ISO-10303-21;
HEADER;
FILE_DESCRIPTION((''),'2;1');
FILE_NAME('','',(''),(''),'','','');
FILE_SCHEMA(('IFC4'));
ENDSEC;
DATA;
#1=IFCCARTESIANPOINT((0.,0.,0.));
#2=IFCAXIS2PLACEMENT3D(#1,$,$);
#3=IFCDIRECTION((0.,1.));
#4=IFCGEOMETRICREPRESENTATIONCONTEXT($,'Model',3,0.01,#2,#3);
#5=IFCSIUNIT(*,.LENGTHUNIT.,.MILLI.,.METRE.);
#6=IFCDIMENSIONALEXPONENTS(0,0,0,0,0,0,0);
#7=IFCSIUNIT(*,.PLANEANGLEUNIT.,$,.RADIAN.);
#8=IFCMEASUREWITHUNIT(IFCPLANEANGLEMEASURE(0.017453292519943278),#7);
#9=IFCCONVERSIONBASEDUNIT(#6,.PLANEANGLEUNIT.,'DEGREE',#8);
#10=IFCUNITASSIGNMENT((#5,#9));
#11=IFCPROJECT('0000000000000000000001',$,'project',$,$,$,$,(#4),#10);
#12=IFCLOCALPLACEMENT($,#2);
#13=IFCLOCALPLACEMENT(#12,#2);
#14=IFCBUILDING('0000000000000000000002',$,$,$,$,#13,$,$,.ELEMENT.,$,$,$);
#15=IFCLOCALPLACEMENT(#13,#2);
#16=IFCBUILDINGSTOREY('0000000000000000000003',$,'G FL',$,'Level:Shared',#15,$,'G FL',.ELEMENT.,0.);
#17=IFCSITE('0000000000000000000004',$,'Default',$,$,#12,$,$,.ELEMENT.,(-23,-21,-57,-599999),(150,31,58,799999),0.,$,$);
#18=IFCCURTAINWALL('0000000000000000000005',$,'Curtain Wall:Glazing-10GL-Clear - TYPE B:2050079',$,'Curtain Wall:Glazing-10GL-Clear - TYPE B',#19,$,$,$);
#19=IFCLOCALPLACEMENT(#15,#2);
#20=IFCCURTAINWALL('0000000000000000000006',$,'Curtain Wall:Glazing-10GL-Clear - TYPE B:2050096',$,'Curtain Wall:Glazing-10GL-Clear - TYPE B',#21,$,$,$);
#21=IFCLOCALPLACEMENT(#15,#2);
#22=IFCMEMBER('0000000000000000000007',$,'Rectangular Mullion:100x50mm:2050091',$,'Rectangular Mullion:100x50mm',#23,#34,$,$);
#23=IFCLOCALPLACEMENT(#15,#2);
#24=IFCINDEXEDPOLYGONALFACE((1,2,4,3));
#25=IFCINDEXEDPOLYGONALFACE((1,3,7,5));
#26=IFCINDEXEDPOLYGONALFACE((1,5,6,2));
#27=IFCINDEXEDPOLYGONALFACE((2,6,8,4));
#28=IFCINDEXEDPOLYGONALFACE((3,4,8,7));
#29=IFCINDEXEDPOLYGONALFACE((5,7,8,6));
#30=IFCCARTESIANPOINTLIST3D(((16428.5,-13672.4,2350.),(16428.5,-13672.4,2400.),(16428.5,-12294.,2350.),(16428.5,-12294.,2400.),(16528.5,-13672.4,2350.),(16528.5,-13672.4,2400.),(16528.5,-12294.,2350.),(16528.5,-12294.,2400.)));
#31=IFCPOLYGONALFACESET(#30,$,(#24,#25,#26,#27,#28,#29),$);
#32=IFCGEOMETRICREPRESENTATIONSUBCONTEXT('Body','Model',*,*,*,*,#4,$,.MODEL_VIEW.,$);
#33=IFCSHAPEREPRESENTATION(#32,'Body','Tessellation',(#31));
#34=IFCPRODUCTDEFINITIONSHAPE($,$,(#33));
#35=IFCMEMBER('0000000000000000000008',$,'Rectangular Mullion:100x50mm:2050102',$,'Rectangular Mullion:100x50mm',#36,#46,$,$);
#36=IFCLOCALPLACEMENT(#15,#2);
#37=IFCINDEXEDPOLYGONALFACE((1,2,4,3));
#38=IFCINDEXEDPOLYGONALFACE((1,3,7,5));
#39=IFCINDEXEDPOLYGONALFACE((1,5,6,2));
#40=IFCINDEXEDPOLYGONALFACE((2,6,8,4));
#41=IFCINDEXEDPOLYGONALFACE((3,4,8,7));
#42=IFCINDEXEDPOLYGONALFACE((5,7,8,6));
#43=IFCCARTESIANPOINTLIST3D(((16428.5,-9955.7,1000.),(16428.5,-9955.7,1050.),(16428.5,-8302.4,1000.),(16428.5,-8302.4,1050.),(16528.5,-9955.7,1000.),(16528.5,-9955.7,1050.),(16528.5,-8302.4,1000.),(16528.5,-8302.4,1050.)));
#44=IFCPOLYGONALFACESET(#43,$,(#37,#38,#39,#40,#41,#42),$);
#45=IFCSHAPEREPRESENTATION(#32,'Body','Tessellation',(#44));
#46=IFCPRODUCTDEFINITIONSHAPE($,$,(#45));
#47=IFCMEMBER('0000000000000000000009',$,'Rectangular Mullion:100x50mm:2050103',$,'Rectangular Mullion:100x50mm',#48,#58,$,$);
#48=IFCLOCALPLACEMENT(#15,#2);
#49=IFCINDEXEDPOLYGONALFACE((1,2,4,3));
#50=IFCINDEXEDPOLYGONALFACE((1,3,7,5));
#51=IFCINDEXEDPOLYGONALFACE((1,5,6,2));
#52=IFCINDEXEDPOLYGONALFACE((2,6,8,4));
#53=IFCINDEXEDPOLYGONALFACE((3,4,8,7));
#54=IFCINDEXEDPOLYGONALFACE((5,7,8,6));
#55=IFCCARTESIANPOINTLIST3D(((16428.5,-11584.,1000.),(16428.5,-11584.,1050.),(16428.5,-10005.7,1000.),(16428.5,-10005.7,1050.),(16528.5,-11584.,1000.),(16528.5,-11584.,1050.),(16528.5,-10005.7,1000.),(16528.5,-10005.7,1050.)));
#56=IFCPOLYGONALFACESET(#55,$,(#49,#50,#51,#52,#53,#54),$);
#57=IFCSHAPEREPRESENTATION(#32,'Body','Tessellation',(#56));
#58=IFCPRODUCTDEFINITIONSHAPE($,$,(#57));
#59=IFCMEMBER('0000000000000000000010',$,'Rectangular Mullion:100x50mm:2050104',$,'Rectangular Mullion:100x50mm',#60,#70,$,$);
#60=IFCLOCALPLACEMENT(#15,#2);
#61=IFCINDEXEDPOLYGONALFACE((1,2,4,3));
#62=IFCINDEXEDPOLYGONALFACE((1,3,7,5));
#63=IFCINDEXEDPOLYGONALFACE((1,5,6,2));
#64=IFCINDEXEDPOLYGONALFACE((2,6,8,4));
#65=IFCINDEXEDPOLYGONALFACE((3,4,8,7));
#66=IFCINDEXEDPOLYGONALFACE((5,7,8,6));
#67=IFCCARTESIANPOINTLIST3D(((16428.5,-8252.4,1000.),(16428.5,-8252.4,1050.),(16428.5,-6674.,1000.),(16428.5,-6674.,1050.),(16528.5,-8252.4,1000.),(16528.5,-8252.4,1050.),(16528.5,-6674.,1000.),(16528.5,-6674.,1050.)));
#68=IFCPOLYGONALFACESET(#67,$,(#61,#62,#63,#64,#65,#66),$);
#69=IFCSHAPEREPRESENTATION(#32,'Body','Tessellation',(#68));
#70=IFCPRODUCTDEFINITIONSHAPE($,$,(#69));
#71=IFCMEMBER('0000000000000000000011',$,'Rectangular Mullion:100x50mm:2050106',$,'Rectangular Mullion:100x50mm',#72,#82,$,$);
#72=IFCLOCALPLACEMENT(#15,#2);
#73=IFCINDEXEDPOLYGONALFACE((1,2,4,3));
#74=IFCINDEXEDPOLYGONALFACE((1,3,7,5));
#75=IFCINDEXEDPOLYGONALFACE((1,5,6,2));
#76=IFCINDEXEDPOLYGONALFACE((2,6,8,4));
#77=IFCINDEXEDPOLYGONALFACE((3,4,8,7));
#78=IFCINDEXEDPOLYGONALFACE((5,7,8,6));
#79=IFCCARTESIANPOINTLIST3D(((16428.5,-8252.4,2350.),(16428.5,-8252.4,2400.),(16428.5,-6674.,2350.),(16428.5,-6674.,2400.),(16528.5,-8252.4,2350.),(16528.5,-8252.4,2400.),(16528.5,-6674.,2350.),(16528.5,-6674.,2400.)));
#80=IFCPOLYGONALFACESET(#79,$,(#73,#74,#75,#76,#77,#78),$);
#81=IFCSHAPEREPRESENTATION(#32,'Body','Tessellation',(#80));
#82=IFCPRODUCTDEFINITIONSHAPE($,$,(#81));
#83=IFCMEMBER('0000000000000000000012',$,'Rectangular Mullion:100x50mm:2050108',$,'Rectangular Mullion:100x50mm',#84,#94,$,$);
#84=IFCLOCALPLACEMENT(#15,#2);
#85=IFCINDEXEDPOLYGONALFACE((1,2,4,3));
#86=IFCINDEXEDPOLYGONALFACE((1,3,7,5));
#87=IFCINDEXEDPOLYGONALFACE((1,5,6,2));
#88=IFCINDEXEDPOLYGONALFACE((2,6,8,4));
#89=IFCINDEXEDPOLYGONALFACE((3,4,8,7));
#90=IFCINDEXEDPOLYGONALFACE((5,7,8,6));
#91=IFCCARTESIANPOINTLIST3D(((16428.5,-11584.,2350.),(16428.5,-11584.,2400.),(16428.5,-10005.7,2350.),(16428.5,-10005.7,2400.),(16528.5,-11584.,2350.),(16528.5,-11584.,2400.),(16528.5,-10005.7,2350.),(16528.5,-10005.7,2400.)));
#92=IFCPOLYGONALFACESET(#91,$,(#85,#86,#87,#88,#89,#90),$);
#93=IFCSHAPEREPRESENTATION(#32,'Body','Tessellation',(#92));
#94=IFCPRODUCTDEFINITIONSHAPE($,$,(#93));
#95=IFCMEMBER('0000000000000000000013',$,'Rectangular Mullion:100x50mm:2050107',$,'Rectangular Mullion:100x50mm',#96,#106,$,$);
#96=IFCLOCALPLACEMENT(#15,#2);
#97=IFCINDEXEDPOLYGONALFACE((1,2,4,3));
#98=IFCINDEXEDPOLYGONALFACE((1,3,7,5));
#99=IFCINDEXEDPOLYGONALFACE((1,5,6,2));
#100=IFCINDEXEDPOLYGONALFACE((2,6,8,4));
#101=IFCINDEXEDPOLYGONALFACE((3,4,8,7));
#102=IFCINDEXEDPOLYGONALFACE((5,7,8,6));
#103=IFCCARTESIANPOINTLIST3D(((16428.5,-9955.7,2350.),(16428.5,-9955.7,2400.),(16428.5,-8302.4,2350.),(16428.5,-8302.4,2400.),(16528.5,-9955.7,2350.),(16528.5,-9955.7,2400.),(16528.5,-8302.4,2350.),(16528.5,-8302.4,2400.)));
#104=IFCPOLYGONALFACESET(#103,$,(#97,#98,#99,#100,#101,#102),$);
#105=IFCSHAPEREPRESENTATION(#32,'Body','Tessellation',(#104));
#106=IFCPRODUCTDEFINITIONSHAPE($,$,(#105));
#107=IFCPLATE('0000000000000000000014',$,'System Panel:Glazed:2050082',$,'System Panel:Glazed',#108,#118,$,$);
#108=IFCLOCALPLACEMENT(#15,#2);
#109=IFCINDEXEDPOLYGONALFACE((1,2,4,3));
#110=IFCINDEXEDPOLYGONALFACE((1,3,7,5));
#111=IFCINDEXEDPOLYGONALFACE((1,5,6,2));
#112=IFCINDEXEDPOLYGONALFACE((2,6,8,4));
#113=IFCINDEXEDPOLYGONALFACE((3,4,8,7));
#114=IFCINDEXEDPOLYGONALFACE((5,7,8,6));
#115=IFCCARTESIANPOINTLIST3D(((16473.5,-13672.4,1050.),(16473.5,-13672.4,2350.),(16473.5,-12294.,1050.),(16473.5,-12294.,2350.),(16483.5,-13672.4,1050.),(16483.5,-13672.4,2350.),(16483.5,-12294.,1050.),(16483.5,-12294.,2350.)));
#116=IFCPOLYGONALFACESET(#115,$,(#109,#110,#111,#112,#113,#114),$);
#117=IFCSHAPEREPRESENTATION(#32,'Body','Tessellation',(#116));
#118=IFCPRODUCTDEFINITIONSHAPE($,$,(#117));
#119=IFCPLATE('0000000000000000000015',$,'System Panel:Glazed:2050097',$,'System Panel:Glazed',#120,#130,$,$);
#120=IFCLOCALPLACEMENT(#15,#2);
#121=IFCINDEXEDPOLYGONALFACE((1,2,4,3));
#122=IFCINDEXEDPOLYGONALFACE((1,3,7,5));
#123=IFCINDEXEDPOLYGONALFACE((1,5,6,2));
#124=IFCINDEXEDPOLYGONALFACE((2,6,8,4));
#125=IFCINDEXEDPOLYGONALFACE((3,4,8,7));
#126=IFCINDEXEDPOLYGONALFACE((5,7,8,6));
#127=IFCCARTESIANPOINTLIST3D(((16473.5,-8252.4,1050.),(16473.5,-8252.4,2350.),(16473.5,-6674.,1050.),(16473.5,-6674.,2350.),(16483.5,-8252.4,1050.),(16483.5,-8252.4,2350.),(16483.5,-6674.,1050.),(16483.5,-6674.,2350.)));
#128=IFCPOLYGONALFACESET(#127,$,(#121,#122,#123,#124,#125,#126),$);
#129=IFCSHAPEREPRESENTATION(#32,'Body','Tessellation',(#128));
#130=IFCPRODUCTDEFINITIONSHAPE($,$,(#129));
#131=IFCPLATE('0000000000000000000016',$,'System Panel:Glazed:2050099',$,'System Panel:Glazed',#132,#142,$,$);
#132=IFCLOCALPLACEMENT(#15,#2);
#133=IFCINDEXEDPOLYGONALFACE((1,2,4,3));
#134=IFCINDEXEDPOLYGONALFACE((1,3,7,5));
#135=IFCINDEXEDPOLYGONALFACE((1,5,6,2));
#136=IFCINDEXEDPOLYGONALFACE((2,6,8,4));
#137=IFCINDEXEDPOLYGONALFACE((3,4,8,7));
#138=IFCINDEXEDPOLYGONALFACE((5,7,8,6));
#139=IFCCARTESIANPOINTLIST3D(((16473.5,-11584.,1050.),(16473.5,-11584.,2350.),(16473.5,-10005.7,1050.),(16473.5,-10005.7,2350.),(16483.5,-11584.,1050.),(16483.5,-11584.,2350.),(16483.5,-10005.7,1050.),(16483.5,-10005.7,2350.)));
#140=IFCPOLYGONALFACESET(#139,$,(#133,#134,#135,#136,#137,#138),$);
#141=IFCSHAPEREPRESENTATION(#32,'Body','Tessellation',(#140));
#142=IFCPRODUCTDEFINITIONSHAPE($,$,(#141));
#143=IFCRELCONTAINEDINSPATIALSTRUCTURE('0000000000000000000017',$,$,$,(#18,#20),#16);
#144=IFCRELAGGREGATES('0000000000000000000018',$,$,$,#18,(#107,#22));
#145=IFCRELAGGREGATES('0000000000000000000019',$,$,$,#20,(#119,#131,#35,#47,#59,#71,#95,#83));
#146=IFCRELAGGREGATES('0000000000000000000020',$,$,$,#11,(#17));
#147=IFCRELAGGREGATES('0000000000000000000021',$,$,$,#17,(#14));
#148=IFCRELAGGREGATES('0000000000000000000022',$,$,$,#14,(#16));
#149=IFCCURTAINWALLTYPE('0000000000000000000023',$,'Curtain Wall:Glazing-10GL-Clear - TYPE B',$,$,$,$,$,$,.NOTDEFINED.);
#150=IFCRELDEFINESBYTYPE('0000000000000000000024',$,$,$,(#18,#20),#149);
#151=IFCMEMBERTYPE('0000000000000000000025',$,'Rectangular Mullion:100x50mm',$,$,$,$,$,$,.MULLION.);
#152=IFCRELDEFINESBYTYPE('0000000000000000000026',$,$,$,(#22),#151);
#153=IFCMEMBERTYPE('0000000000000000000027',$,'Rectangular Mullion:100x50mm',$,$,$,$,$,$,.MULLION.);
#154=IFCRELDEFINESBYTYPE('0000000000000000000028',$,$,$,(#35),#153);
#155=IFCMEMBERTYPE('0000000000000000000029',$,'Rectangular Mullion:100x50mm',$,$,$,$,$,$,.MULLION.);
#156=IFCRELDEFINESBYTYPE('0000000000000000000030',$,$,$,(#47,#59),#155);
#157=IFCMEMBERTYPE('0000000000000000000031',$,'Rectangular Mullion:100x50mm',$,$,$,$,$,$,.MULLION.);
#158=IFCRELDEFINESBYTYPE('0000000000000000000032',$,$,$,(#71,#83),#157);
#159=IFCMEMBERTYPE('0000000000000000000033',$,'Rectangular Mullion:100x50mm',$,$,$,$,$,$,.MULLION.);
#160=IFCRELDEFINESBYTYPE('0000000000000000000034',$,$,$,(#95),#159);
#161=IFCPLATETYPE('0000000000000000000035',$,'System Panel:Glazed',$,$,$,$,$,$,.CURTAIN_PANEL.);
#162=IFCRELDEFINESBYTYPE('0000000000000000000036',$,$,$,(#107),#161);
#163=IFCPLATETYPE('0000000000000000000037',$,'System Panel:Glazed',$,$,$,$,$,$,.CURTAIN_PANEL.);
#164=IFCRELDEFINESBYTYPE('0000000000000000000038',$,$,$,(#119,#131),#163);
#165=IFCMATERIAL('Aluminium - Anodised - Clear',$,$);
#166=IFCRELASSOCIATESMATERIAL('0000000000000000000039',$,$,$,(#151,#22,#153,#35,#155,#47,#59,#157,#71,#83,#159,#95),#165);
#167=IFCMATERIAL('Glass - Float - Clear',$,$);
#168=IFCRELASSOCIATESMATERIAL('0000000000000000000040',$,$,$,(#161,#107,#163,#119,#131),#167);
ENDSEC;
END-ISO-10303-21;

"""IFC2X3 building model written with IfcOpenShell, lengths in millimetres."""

from ifc_helpers import new_model, entity, si_unit, converted_unit, direction, frame, frame_2d, origin, origin_2d_with_axis, place, context, subcontext, project, spatial, rectangle, extrude, source, transform, mapped, material, type_object, type_shapes, element, aggregate, save


model = new_model("IFC2X3")

# Units and contexts
model_context = context("Model", 3, precision=0.01, world=origin(), true_north=direction((0.0, 1.0)))
body_context = subcontext(model_context, "Body", "Model", "MODEL_VIEW")
ifc_project = project(units=[si_unit("LENGTHUNIT", "METRE", prefix="MILLI"), converted_unit("PLANEANGLEUNIT", "DEGREE", entity("IfcPlaneAngleMeasure", 0.017453292519943278), si_unit("PLANEANGLEUNIT", "RADIAN"), dimensions=[0, 0, 0, 0, 0, 0, 0])], contexts=[model_context])

# Site, building, storey
site_placement = place(None, origin())
site = spatial("IfcSite", under=ifc_project, at=site_placement, Name="Default", CompositionType="ELEMENT", RefLatitude=(-23, -21, -57, -599999), RefLongitude=(150, 31, 58, 799999), RefElevation=0.0)
building_placement = place(site_placement, origin())
building = spatial("IfcBuilding", under=site, at=building_placement, CompositionType="ELEMENT")
storey_placement = place(building_placement, origin())
storey = spatial("IfcBuildingStorey", under=building, at=storey_placement, Name="G FL", ObjectType="Level:Shared", LongName="G FL", CompositionType="ELEMENT", Elevation=0.0)

# Curtain walls
curtain_wall_type = type_object("IfcCurtainWallType", Name="Curtain Wall:Glazing-10GL-Clear - TYPE B", PredefinedType="NOTDEFINED")
curtain_wall_1_placement = place(storey_placement, origin())
curtain_wall_1 = element("IfcCurtainWall", 1, at=curtain_wall_1_placement, inside=storey, type_object=curtain_wall_type, Name="Curtain Wall:Glazing-10GL-Clear - TYPE B:2050079", ObjectType="Curtain Wall:Glazing-10GL-Clear - TYPE B")
ifc_material_1 = material(Name="Aluminium - Anodised - Clear")
curtain_wall_2_placement = place(storey_placement, origin())
curtain_wall_2 = element("IfcCurtainWall", 2, at=curtain_wall_2_placement, inside=storey, type_object=curtain_wall_type, Name="Curtain Wall:Glazing-10GL-Clear - TYPE B:2050096", ObjectType="Curtain Wall:Glazing-10GL-Clear - TYPE B")

# Members
member_type_1 = type_object("IfcMemberType", Name="Rectangular Mullion:100x50mm", PredefinedType="MULLION", material=ifc_material_1)
shared_shape_1 = source(origin(), body_context, "Body", "SweptSolid", [
    extrude(rectangle(XDim=50.0, YDim=100.0, at=frame_2d((0.0, 0.0), x_axis=(1.0, 0.0))), frame((-25.0, 0.0, -1378.3), z_axis=(0.0, 0.0, 1.0), x_axis=(-1.0, 0.0, 0.0)), (0.0, 0.0, 1.0), 1378.3),
])
type_shapes(member_type_1, [shared_shape_1])
member_1_placement = place(curtain_wall_1_placement, frame((16478.5, -12294.0, 2400.0), z_axis=(0.0, 1.0, 0.0), x_axis=(0.0, 0.0, 1.0)))
member_1 = element("IfcMember", 3, at=member_1_placement, type_object=member_type_1, material=ifc_material_1, Name="Rectangular Mullion:100x50mm:2050091", ObjectType="Rectangular Mullion:100x50mm", context=body_context, shape_type="MappedRepresentation", body=[
    mapped(shared_shape_1, transform((0.0, 0.0, 0.0), scale=1.0)),
])
member_type_2 = type_object("IfcMemberType", Name="Rectangular Mullion:100x50mm", PredefinedType="MULLION", material=ifc_material_1)
shared_shape_2 = source(origin(), body_context, "Body", "SweptSolid", [
    extrude(rectangle(XDim=50.0, YDim=100.0, at=frame_2d((0.0, 0.0), x_axis=(1.0, 0.0))), frame((-25.0, 0.0, -1653.3), z_axis=(0.0, 0.0, 1.0), x_axis=(-1.0, 0.0, 0.0)), (0.0, 0.0, 1.0), 1653.3),
])
type_shapes(member_type_2, [shared_shape_2])
member_2_placement = place(curtain_wall_2_placement, frame((16478.5, -8302.4, 1000.0), z_axis=(0.0, 1.0, 0.0), x_axis=(0.0, 0.0, -1.0)))
member_2 = element("IfcMember", 4, at=member_2_placement, type_object=member_type_2, material=ifc_material_1, Name="Rectangular Mullion:100x50mm:2050102", ObjectType="Rectangular Mullion:100x50mm", context=body_context, shape_type="MappedRepresentation", body=[
    mapped(shared_shape_2, transform((0.0, 0.0, 0.0), scale=1.0)),
])
member_type_3 = type_object("IfcMemberType", Name="Rectangular Mullion:100x50mm", PredefinedType="MULLION", material=ifc_material_1)
shared_shape_3 = source(origin(), body_context, "Body", "SweptSolid", [
    extrude(rectangle(XDim=50.0, YDim=100.0, at=frame_2d((0.0, 0.0), x_axis=(1.0, 0.0))), frame((-25.0, 0.0, -1578.3), z_axis=(0.0, 0.0, 1.0), x_axis=(-1.0, 0.0, 0.0)), (0.0, 0.0, 1.0), 1578.3),
])
type_shapes(member_type_3, [shared_shape_3])
member_3_placement = place(curtain_wall_2_placement, frame((16478.5, -10005.7, 1000.0), z_axis=(0.0, 1.0, 0.0), x_axis=(0.0, 0.0, -1.0)))
member_3 = element("IfcMember", 5, at=member_3_placement, type_object=member_type_3, material=ifc_material_1, Name="Rectangular Mullion:100x50mm:2050103", ObjectType="Rectangular Mullion:100x50mm", context=body_context, shape_type="MappedRepresentation", body=[
    mapped(shared_shape_3, transform((0.0, 0.0, 0.0), scale=1.0)),
])
member_4_placement = place(curtain_wall_2_placement, frame((16478.5, -6674.0, 1000.0), z_axis=(0.0, 1.0, 0.0), x_axis=(0.0, 0.0, -1.0)))
member_4 = element("IfcMember", 6, at=member_4_placement, type_object=member_type_3, material=ifc_material_1, Name="Rectangular Mullion:100x50mm:2050104", ObjectType="Rectangular Mullion:100x50mm", context=body_context, shape_type="MappedRepresentation", body=[
    mapped(shared_shape_3, transform((0.0, 0.0, 0.0), scale=1.0)),
])
member_type_4 = type_object("IfcMemberType", Name="Rectangular Mullion:100x50mm", PredefinedType="MULLION", material=ifc_material_1)
shared_shape_4 = source(origin(), body_context, "Body", "SweptSolid", [
    extrude(rectangle(XDim=50.0, YDim=100.0, at=frame_2d((0.0, 0.0), x_axis=(1.0, 0.0))), frame((-25.0, 0.0, -1578.3), z_axis=(0.0, 0.0, 1.0), x_axis=(-1.0, 0.0, 0.0)), (0.0, 0.0, 1.0), 1578.3),
])
type_shapes(member_type_4, [shared_shape_4])
member_5_placement = place(curtain_wall_2_placement, frame((16478.5, -8252.4, 2400.0), z_axis=(0.0, -1.0, 0.0), x_axis=(0.0, 0.0, 1.0)))
member_5 = element("IfcMember", 7, at=member_5_placement, type_object=member_type_4, material=ifc_material_1, Name="Rectangular Mullion:100x50mm:2050106", ObjectType="Rectangular Mullion:100x50mm", context=body_context, shape_type="MappedRepresentation", body=[
    mapped(shared_shape_4, transform((0.0, 0.0, 0.0), scale=1.0)),
])
member_6_placement = place(curtain_wall_2_placement, frame((16478.5, -11584.0, 2400.0), z_axis=(0.0, -1.0, 0.0), x_axis=(0.0, 0.0, 1.0)))
member_6 = element("IfcMember", 8, at=member_6_placement, type_object=member_type_4, material=ifc_material_1, Name="Rectangular Mullion:100x50mm:2050108", ObjectType="Rectangular Mullion:100x50mm", context=body_context, shape_type="MappedRepresentation", body=[
    mapped(shared_shape_4, transform((0.0, 0.0, 0.0), scale=1.0)),
])
member_type_5 = type_object("IfcMemberType", Name="Rectangular Mullion:100x50mm", PredefinedType="MULLION", material=ifc_material_1)
shared_shape_5 = source(origin(), body_context, "Body", "SweptSolid", [
    extrude(rectangle(XDim=50.0, YDim=100.0, at=frame_2d((0.0, 0.0), x_axis=(1.0, 0.0))), frame((-25.0, 0.0, -1653.3), z_axis=(0.0, 0.0, 1.0), x_axis=(-1.0, 0.0, 0.0)), (0.0, 0.0, 1.0), 1653.3),
])
type_shapes(member_type_5, [shared_shape_5])
member_7_placement = place(curtain_wall_2_placement, frame((16478.5, -9955.7, 2400.0), z_axis=(0.0, -1.0, 0.0), x_axis=(0.0, 0.0, 1.0)))
member_7 = element("IfcMember", 9, at=member_7_placement, type_object=member_type_5, material=ifc_material_1, Name="Rectangular Mullion:100x50mm:2050107", ObjectType="Rectangular Mullion:100x50mm", context=body_context, shape_type="MappedRepresentation", body=[
    mapped(shared_shape_5, transform((0.0, 0.0, 0.0), scale=1.0)),
])

# Plates
ifc_material_2 = material(Name="Glass - Float - Clear")
plate_type_1 = type_object("IfcPlateType", Name="System Panel:Glazed", PredefinedType="CURTAIN_PANEL", material=ifc_material_2)
shared_shape_6 = source(origin(), body_context, "Body", "SweptSolid", [
    extrude(rectangle(XDim=10.0, YDim=1378.3, at=origin_2d_with_axis()), frame((0.0, 0.0, 0.0), z_axis=(0.0, 0.0, 1.0), x_axis=(0.0, 1.0, 0.0)), (0.0, 0.0, 1.0), 1300.0),
])
type_shapes(plate_type_1, [shared_shape_6])
plate_1_placement = place(curtain_wall_1_placement, frame((16478.5, -12983.2, 1050.0), z_axis=(0.0, 0.0, 1.0), x_axis=(0.0, 1.0, 0.0)))
plate_1 = element("IfcPlate", 10, at=plate_1_placement, type_object=plate_type_1, material=ifc_material_2, Name="System Panel:Glazed:2050082", ObjectType="System Panel:Glazed", context=body_context, shape_type="MappedRepresentation", body=[
    mapped(shared_shape_6, transform((0.0, 0.0, 0.0), scale=1.0)),
])
aggregate(curtain_wall_1, [plate_1, member_1])
plate_type_2 = type_object("IfcPlateType", Name="System Panel:Glazed", PredefinedType="CURTAIN_PANEL", material=ifc_material_2)
shared_shape_7 = source(origin(), body_context, "Body", "SweptSolid", [
    extrude(rectangle(XDim=10.0, YDim=1578.3, at=origin_2d_with_axis()), frame((0.0, 0.0, 0.0), z_axis=(0.0, 0.0, 1.0), x_axis=(0.0, 1.0, 0.0)), (0.0, 0.0, 1.0), 1300.0),
])
type_shapes(plate_type_2, [shared_shape_7])
plate_2_placement = place(curtain_wall_2_placement, frame((16478.5, -7463.2, 1050.0), z_axis=(0.0, 0.0, 1.0), x_axis=(0.0, -1.0, 0.0)))
plate_2 = element("IfcPlate", 11, at=plate_2_placement, type_object=plate_type_2, material=ifc_material_2, Name="System Panel:Glazed:2050097", ObjectType="System Panel:Glazed", context=body_context, shape_type="MappedRepresentation", body=[
    mapped(shared_shape_7, transform((0.0, 0.0, 0.0), scale=1.0)),
])
plate_3_placement = place(curtain_wall_2_placement, frame((16478.5, -10794.9, 1050.0), z_axis=(0.0, 0.0, 1.0), x_axis=(0.0, -1.0, 0.0)))
plate_3 = element("IfcPlate", 12, at=plate_3_placement, type_object=plate_type_2, material=ifc_material_2, Name="System Panel:Glazed:2050099", ObjectType="System Panel:Glazed", context=body_context, shape_type="MappedRepresentation", body=[
    mapped(shared_shape_7, transform((0.0, 0.0, 0.0), scale=1.0)),
])
aggregate(curtain_wall_2, [plate_2, plate_3, member_2, member_3, member_4, member_5, member_7, member_6])

save(model, "model.ifc")
